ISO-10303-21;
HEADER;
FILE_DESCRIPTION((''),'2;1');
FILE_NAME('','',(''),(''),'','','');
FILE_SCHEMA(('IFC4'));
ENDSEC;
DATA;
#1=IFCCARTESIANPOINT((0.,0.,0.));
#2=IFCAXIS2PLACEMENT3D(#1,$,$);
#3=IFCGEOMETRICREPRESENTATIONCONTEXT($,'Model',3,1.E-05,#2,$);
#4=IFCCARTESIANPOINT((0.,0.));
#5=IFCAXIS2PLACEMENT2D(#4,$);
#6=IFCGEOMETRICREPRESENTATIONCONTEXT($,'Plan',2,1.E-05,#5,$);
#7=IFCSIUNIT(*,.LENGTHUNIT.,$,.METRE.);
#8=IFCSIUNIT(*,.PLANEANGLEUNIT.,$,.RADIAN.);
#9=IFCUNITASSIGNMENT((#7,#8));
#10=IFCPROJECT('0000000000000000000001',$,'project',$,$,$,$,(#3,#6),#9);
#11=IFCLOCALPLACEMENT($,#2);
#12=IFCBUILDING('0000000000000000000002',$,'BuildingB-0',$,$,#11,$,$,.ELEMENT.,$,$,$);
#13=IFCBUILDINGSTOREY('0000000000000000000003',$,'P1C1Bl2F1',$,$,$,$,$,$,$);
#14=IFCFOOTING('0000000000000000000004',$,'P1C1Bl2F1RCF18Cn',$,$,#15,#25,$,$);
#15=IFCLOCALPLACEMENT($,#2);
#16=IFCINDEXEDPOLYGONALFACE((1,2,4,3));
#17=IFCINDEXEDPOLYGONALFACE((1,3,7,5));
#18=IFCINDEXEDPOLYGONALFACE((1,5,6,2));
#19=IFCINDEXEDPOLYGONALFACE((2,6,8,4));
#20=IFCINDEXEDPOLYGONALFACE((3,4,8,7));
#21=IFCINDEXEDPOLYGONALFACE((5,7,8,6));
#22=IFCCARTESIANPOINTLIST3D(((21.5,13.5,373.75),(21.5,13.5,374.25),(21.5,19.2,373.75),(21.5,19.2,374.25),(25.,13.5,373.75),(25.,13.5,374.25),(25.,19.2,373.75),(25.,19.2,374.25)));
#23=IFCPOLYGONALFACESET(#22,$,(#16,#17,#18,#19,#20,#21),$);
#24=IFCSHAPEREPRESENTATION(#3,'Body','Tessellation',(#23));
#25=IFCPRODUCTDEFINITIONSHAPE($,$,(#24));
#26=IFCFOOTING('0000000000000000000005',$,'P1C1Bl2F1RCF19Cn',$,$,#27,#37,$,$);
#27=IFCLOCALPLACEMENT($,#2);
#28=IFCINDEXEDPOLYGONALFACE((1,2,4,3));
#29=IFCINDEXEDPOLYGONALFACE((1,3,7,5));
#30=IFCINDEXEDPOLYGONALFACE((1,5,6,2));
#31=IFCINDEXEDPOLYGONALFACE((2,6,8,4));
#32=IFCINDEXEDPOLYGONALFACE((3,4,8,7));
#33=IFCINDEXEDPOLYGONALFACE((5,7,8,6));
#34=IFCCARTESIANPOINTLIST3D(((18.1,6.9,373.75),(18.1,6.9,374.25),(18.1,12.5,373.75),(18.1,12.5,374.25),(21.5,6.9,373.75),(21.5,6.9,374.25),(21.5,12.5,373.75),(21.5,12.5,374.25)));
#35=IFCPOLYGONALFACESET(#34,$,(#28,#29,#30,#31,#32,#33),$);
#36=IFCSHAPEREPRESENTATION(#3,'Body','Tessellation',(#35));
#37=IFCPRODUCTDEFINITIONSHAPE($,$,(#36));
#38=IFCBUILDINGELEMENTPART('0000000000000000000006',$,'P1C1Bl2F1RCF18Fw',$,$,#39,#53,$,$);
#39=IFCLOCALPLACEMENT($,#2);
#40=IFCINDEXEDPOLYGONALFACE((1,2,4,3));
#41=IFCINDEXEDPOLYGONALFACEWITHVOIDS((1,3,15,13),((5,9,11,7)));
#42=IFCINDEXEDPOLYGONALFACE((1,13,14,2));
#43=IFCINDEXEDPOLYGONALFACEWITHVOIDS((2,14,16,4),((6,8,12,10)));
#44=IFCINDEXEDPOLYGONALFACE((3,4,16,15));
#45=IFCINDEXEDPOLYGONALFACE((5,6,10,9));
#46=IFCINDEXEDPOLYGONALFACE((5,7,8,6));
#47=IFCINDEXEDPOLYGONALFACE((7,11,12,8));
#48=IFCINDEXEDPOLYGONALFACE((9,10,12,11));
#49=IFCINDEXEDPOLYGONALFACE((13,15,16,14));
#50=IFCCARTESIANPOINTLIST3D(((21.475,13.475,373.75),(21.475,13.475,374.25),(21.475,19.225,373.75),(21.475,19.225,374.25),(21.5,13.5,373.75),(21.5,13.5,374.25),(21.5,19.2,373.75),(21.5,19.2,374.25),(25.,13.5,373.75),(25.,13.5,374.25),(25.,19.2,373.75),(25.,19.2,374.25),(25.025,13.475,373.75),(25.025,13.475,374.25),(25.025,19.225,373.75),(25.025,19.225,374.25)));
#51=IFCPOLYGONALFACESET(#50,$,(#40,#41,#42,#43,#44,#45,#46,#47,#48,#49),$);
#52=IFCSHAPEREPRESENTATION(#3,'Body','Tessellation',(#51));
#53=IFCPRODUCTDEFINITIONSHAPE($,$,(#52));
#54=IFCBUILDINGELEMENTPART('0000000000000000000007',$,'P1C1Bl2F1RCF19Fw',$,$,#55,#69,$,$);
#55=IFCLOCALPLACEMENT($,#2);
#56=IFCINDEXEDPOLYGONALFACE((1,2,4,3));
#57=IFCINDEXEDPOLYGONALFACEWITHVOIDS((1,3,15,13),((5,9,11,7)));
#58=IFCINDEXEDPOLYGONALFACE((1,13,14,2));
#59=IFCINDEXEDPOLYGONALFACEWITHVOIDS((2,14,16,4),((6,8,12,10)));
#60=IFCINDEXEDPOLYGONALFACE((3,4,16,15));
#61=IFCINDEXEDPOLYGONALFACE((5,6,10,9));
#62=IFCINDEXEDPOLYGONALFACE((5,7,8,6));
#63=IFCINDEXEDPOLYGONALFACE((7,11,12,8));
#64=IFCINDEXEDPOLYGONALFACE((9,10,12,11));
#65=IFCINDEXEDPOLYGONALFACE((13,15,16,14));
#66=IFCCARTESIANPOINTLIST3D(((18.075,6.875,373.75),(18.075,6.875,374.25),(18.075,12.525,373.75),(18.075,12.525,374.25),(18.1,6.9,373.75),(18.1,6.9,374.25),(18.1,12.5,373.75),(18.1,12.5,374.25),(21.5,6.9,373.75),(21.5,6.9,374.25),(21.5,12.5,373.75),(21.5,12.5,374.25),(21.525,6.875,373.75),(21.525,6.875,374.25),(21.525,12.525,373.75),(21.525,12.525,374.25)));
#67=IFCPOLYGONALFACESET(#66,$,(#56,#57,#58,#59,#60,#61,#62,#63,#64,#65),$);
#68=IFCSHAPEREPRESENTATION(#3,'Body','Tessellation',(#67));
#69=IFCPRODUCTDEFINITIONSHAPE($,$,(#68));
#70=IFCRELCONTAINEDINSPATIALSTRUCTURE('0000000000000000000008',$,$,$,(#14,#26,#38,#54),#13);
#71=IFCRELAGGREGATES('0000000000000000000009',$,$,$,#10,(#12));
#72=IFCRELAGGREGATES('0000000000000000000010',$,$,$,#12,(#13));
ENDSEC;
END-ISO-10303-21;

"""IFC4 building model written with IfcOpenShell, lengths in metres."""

from ifc_helpers import new_model, si_unit, origin, origin_2d, place, context, project, spatial, polyline, outline, extrude, element, save


model = new_model("IFC4")

# Units and contexts
model_context = context("Model", 3, precision=1e-05, world=origin())
plan_context = context("Plan", 2, precision=1e-05, world=origin_2d())
ifc_project = project(units=[si_unit("LENGTHUNIT", "METRE"), si_unit("PLANEANGLEUNIT", "RADIAN")], contexts=[model_context, plan_context])

# Building, storey
building_placement = place(None, origin())
building = spatial("IfcBuilding", under=ifc_project, at=building_placement, Name="BuildingB-0", CompositionType="ELEMENT")
storey = spatial("IfcBuildingStorey", under=building, Name="P1C1Bl2F1")

# Footings
element("IfcFooting", 1, inside=storey, Name="P1C1Bl2F1RCF18Cn", context=model_context, shape_type="SweptSolid", body=[
    extrude(outline(polyline([(25.0, 19.2, 373.75), (21.5, 19.2, 373.75), (21.5, 13.5, 373.75), (25.0, 13.5, 373.75), (25.0, 19.2, 373.75)])), None, (0.0, 0.0, 1.0), 0.5),
])
element("IfcFooting", 2, inside=storey, Name="P1C1Bl2F1RCF19Cn", context=model_context, shape_type="SweptSolid", body=[
    extrude(outline(polyline([(21.5, 12.5, 373.75), (18.1, 12.5, 373.75), (18.1, 6.9, 373.75), (21.5, 6.9, 373.75), (21.5, 12.5, 373.75)])), None, (0.0, 0.0, 1.0), 0.5),
])

# Building element part, opening
building_element_part_1 = element("IfcBuildingElementPart", 3, inside=storey, Name="P1C1Bl2F1RCF18Fw", context=model_context, shape_type="SweptSolid", body=[
    extrude(outline(polyline([(25.025, 19.225, 373.75), (21.475, 19.225, 373.75), (21.475, 13.475, 373.75), (25.025, 13.475, 373.75), (25.025, 19.225, 373.75)])), None, (0.0, 0.0, 1.0), 0.5),
])
element("IfcOpeningElement", 4, inside=storey, cuts=building_element_part_1, context=model_context, shape_type="SweptSolid", body=[
    extrude(outline(polyline([(25.0, 19.2, 373.75), (21.5, 19.2, 373.75), (21.5, 13.5, 373.75), (25.0, 13.5, 373.75), (25.0, 19.2, 373.75)])), None, (0.0, 0.0, 1.0), 0.5),
])

# Building element part, opening
building_element_part_2 = element("IfcBuildingElementPart", 5, inside=storey, Name="P1C1Bl2F1RCF19Fw", context=model_context, shape_type="SweptSolid", body=[
    extrude(outline(polyline([(21.525, 12.525, 373.75), (18.075, 12.525, 373.75), (18.075, 6.875, 373.75), (21.525, 6.875, 373.75), (21.525, 12.525, 373.75)])), None, (0.0, 0.0, 1.0), 0.5),
])
element("IfcOpeningElement", 6, inside=storey, cuts=building_element_part_2, context=model_context, shape_type="SweptSolid", body=[
    extrude(outline(polyline([(21.5, 12.5, 373.75), (18.1, 12.5, 373.75), (18.1, 6.9, 373.75), (21.5, 6.9, 373.75), (21.5, 12.5, 373.75)])), None, (0.0, 0.0, 1.0), 0.5),
])

save(model, "model.ifc")
